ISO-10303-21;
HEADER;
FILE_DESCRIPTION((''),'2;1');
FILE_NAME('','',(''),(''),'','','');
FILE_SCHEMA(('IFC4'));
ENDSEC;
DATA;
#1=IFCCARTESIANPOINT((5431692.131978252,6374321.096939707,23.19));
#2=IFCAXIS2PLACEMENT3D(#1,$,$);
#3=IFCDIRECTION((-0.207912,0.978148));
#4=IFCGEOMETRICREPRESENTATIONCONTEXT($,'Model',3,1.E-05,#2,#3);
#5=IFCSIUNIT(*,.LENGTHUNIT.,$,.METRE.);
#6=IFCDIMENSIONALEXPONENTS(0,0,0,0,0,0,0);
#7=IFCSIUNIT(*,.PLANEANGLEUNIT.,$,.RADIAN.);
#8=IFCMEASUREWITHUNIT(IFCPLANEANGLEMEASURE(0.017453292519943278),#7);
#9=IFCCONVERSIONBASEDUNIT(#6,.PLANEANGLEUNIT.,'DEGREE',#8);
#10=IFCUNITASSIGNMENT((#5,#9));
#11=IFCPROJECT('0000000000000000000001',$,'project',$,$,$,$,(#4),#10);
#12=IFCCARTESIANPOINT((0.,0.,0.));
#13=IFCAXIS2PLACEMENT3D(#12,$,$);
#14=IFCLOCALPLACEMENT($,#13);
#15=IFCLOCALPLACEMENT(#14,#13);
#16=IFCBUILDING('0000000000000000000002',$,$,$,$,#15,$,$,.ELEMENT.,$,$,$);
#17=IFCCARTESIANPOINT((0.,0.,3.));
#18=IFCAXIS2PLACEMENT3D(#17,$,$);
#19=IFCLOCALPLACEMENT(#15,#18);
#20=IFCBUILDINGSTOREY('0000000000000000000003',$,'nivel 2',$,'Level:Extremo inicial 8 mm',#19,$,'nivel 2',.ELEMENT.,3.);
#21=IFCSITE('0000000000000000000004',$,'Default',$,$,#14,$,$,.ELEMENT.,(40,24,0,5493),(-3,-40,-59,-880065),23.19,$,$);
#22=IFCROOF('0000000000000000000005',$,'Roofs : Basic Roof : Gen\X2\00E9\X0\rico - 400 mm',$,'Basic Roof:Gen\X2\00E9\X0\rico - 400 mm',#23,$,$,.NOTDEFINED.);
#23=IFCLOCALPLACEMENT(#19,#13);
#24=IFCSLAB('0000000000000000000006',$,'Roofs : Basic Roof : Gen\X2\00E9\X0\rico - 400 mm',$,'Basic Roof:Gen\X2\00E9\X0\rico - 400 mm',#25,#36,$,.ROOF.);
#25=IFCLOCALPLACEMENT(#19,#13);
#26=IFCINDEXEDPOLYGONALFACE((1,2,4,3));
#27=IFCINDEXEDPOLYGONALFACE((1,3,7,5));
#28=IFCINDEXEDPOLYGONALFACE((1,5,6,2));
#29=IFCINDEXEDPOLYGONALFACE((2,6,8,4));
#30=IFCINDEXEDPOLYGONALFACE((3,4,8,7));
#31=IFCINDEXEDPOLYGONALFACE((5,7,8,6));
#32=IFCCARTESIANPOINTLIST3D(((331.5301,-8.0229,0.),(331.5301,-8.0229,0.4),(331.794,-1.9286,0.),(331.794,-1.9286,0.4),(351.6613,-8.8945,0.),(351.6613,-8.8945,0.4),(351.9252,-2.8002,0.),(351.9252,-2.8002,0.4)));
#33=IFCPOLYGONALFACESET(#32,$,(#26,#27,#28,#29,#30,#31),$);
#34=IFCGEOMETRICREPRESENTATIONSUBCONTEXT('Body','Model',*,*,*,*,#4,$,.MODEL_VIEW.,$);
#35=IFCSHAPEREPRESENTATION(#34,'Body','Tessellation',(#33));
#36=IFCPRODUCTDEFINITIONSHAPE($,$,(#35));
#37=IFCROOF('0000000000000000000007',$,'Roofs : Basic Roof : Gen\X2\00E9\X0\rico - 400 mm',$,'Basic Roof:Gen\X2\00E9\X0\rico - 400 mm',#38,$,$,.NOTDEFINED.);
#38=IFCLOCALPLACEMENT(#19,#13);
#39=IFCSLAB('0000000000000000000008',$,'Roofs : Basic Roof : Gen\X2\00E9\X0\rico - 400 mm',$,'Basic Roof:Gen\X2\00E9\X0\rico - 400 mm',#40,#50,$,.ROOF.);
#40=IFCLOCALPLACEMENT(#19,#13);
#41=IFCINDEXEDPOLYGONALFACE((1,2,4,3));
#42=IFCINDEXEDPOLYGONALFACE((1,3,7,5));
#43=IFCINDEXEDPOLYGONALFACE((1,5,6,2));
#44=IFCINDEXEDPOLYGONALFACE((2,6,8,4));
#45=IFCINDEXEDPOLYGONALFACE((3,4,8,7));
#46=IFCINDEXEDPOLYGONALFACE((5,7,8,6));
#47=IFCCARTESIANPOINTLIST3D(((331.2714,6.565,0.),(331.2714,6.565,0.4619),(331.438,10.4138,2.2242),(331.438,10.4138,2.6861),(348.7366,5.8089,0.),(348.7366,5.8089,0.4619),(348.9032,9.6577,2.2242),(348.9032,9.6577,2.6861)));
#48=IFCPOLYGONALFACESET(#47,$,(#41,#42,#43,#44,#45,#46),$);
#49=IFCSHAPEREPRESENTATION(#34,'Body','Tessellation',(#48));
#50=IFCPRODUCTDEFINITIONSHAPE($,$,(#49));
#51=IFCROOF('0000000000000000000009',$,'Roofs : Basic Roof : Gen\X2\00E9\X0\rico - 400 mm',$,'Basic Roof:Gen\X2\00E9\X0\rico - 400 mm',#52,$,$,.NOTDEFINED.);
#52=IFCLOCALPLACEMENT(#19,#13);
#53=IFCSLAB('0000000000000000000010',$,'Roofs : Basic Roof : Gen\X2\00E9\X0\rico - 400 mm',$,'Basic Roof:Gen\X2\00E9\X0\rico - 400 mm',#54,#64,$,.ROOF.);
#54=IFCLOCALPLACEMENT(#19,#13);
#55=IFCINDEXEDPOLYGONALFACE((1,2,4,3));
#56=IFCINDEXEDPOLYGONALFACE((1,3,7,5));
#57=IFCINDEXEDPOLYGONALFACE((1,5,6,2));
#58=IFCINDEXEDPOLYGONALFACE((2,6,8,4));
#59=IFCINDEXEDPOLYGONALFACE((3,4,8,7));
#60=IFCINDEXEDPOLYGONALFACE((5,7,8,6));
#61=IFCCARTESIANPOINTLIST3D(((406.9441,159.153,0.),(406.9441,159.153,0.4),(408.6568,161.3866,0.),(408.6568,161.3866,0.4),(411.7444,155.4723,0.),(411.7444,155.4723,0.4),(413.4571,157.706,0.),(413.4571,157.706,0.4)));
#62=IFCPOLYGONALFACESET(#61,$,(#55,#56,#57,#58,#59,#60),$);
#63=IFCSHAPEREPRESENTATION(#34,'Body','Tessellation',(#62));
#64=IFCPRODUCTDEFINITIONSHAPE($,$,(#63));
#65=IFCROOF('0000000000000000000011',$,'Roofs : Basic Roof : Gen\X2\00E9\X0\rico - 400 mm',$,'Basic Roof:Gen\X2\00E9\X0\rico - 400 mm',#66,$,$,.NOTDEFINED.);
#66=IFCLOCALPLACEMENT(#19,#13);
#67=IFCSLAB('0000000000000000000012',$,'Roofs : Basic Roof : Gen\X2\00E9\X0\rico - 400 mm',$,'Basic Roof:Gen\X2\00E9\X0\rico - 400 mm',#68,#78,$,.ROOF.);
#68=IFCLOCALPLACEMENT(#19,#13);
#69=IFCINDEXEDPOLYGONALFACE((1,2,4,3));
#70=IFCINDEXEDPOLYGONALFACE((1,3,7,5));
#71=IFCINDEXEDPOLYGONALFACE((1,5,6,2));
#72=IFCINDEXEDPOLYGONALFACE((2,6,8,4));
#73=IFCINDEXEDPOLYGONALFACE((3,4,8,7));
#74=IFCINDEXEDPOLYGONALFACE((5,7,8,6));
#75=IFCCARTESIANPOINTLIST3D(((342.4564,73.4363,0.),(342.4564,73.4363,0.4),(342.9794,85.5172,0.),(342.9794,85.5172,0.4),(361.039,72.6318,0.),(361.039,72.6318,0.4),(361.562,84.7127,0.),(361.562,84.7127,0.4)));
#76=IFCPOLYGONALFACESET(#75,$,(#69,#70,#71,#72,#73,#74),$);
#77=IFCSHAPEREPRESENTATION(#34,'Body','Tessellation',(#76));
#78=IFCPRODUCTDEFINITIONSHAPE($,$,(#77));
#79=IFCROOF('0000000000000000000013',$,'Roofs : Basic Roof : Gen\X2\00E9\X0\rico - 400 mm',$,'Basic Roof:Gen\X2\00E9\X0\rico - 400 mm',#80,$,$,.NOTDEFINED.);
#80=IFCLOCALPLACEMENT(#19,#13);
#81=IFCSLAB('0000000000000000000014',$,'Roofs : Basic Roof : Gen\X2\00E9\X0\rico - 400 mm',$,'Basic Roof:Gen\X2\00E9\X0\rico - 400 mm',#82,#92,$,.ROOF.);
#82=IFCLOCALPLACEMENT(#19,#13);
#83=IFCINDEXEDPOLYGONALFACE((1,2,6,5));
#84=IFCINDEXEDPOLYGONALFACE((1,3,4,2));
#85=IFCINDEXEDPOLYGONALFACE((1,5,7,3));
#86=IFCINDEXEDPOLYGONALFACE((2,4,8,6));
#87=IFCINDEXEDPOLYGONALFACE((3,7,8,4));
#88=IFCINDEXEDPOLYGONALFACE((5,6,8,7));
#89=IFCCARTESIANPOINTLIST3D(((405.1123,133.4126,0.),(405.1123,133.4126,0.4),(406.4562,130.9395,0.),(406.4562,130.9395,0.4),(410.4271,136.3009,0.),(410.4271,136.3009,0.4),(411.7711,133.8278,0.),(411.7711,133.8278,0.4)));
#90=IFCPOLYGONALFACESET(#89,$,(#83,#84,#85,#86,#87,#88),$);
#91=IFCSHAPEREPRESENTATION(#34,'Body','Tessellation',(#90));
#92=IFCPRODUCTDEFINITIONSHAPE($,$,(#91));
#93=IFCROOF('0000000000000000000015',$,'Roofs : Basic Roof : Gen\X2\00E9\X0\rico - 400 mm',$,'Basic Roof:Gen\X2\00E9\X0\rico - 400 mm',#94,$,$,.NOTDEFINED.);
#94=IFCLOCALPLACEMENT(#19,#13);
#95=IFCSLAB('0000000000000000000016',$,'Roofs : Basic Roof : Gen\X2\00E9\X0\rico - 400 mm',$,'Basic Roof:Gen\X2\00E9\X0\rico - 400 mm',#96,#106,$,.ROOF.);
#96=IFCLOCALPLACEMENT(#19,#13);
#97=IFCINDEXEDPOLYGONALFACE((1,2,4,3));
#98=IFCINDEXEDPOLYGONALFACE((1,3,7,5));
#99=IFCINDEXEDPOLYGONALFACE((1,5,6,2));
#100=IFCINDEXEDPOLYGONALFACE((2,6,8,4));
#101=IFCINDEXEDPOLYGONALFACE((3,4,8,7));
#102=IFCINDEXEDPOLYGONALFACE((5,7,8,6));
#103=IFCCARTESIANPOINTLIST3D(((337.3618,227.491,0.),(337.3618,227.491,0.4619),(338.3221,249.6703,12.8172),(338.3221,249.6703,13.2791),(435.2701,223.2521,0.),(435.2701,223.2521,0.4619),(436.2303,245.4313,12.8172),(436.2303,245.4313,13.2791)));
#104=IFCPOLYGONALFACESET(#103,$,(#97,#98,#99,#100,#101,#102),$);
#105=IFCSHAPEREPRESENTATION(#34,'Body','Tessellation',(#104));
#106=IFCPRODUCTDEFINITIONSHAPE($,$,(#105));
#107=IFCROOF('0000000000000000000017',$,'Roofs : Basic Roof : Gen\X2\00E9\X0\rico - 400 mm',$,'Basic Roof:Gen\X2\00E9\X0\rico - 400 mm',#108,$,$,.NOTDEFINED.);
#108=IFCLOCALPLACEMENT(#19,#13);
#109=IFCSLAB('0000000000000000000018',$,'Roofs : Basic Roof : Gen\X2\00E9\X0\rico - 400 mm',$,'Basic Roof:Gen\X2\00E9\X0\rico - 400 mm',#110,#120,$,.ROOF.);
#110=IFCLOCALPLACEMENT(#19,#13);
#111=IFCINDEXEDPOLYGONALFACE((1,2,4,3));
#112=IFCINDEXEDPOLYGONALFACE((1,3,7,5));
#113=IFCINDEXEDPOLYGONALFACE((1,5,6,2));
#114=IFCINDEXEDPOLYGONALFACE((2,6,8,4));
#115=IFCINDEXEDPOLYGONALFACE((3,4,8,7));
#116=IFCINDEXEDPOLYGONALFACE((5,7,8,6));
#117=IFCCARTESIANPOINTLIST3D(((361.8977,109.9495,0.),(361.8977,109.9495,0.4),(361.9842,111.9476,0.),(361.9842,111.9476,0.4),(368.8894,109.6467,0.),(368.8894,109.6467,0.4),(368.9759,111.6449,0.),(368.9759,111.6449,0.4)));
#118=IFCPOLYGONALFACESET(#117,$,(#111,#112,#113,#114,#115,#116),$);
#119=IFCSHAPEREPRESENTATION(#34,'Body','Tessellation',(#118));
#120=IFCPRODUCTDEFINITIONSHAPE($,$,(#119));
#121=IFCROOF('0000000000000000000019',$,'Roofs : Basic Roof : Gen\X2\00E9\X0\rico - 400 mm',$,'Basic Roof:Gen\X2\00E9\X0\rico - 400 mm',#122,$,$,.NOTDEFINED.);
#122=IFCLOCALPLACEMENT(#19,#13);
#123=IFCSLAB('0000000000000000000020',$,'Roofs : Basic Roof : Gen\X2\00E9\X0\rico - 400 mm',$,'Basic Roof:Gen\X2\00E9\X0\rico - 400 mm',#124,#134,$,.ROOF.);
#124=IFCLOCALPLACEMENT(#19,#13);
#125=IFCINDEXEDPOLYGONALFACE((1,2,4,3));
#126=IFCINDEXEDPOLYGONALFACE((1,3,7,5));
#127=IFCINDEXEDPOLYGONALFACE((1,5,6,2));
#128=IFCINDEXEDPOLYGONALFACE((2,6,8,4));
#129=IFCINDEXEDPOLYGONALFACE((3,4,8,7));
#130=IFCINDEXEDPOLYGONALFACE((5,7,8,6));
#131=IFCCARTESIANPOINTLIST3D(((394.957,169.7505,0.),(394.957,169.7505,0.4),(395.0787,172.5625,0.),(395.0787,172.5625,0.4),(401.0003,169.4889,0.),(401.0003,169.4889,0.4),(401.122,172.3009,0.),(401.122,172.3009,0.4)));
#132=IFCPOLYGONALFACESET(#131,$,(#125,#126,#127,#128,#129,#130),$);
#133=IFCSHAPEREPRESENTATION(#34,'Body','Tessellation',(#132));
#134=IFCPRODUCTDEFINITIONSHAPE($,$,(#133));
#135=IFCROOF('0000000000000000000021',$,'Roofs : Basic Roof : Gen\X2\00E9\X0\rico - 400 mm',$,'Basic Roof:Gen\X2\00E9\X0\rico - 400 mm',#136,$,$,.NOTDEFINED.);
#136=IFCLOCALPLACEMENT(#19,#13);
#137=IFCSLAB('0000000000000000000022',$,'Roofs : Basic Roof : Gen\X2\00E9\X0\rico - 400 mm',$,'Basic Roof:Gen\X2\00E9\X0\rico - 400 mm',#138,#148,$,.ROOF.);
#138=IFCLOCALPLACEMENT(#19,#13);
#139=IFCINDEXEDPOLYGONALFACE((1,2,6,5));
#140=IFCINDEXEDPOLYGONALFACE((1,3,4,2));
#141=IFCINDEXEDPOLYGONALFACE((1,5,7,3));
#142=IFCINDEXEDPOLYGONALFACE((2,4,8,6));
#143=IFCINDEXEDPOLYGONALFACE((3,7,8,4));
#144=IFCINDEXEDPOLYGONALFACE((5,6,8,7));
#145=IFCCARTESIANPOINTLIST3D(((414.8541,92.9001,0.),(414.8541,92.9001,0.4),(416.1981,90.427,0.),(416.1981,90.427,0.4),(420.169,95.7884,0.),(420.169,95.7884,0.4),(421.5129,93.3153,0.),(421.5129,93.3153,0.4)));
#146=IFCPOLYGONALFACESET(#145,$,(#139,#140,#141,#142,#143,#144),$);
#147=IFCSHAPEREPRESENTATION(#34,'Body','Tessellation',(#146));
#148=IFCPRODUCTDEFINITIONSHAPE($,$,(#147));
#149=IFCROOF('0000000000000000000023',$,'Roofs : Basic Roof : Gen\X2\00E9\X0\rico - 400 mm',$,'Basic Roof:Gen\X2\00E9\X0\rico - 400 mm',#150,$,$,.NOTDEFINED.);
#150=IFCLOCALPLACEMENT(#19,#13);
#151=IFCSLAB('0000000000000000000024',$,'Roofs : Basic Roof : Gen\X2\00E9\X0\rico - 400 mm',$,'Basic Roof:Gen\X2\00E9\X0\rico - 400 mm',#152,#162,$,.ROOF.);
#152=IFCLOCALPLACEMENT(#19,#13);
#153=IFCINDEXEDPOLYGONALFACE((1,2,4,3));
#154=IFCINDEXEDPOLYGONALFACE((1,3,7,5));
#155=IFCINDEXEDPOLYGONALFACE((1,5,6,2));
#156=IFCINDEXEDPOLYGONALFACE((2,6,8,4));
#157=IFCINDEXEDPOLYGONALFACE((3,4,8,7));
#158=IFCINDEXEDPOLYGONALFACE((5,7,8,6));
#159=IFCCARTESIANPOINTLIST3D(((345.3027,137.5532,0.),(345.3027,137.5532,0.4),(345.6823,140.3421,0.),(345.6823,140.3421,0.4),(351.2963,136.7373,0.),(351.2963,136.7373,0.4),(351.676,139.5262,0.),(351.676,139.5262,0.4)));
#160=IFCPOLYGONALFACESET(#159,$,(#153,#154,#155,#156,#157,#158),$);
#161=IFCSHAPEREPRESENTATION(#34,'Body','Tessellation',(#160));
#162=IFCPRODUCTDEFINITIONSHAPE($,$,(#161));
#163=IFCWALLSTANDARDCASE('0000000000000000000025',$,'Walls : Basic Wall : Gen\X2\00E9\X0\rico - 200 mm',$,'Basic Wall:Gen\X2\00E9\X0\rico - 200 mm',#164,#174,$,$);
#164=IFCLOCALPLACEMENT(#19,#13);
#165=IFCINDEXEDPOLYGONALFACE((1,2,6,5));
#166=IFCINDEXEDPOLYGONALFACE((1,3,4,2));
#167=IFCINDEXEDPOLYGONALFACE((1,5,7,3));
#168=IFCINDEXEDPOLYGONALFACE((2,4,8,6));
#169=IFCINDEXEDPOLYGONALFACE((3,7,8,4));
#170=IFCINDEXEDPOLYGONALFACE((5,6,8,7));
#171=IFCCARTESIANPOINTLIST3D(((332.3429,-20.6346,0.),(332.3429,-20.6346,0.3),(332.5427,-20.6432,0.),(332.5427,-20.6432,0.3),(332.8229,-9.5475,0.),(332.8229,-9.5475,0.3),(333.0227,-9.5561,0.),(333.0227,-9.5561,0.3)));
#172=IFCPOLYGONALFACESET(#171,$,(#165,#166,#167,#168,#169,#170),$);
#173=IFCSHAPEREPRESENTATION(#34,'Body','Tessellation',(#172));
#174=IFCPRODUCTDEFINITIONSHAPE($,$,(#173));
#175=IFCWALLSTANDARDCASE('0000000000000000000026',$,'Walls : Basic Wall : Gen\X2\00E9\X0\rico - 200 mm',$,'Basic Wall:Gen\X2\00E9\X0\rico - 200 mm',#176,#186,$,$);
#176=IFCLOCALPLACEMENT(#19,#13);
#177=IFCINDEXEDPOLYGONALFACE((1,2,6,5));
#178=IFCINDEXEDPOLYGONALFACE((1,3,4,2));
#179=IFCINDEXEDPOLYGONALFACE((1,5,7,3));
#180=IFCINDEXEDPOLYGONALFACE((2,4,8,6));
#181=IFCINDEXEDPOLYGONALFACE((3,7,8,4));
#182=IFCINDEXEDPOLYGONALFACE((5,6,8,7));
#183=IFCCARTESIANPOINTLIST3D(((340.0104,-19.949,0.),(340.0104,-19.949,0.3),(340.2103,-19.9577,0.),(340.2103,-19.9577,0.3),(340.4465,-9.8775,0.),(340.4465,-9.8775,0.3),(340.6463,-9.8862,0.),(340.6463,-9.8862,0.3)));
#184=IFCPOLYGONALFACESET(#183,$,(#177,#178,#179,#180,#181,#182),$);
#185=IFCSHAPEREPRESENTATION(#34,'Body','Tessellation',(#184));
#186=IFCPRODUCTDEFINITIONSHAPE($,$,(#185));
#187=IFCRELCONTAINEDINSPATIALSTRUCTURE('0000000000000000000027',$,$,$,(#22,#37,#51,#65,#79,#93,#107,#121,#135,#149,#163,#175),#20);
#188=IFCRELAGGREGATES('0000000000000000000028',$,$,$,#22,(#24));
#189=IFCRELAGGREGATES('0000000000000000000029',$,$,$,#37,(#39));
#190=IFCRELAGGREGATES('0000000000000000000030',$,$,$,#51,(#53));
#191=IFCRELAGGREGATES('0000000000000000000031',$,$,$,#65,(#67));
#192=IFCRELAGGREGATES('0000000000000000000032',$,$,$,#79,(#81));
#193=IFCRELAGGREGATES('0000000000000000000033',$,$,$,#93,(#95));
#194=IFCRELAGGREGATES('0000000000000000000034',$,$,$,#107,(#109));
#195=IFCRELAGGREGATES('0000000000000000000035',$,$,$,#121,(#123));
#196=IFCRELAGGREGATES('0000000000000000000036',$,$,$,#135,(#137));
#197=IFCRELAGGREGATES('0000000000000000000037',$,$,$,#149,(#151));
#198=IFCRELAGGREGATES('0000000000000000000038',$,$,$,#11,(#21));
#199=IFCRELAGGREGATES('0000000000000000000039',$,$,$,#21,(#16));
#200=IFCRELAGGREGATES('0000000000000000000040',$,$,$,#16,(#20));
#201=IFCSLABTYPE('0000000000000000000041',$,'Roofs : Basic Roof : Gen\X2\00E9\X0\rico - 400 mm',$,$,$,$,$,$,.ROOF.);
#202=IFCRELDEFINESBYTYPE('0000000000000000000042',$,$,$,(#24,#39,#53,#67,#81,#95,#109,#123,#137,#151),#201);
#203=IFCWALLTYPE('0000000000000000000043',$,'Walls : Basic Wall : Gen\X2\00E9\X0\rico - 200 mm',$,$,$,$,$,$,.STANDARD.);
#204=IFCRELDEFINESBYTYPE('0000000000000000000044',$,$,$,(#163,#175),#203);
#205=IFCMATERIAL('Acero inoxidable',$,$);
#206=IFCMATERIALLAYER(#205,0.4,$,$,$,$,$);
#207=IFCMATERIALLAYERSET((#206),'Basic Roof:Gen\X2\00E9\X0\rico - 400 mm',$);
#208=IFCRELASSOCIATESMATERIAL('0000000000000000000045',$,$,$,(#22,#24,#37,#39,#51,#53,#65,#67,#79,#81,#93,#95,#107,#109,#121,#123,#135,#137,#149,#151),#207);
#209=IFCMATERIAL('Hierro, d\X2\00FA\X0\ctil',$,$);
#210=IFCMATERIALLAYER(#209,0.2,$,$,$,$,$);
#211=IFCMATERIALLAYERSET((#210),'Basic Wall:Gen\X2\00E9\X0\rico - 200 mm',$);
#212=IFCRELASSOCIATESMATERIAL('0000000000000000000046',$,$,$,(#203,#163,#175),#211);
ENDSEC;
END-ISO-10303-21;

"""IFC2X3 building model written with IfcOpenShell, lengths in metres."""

from ifc_helpers import new_model, entity, si_unit, converted_unit, direction, frame, frame_2d, origin, place, context, subcontext, project, spatial, rectangle, extrude, material, layer, layer_set, layer_usage, type_object, element, aggregate, save


model = new_model("IFC2X3")

# Units and contexts
model_context = context("Model", 3, precision=1e-05, world=frame((5431692.131978252, 6374321.096939707, 23.19)), true_north=direction((-0.207912, 0.978148)))
body_context = subcontext(model_context, "Body", "Model", "MODEL_VIEW")
ifc_project = project(units=[si_unit("LENGTHUNIT", "METRE"), converted_unit("PLANEANGLEUNIT", "DEGREE", entity("IfcPlaneAngleMeasure", 0.017453292519943278), si_unit("PLANEANGLEUNIT", "RADIAN"), dimensions=[0, 0, 0, 0, 0, 0, 0])], contexts=[model_context])

# Site, building, storey
site_placement = place(None, origin())
site = spatial("IfcSite", under=ifc_project, at=site_placement, Name="Default", CompositionType="ELEMENT", RefLatitude=(40, 24, 0, 5493), RefLongitude=(-3, -40, -59, -880065), RefElevation=23.19)
building_placement = place(site_placement, origin())
building = spatial("IfcBuilding", under=site, at=building_placement, CompositionType="ELEMENT")
storey_placement = place(building_placement, frame((0.0, 0.0, 3.0)))
storey = spatial("IfcBuildingStorey", under=building, at=storey_placement, Name="nivel 2", ObjectType="Level:Extremo inicial 8 mm", LongName="nivel 2", CompositionType="ELEMENT", Elevation=3.0)

# Roof, slab
ifc_material_1 = material(Name="Acero inoxidable")
ifc_layer_1 = layer(ifc_material_1, 0.4)
ifc_layer_set_1 = layer_set([ifc_layer_1], Name="Basic Roof:Genérico - 400 mm")
roof_1_placement = place(storey_placement, frame((331.5301, -8.8945, 0.0)))
roof_1 = element("IfcRoof", 1, at=roof_1_placement, inside=storey, material=ifc_layer_set_1, Name="Roofs : Basic Roof : Genérico - 400 mm", ObjectType="Basic Roof:Genérico - 400 mm", ShapeType="NOTDEFINED")
slab_type = type_object("IfcSlabType", Name="Roofs : Basic Roof : Genérico - 400 mm", PredefinedType="ROOF")
slab_1_placement = place(roof_1_placement, origin())
slab_1 = element("IfcSlab", 2, at=slab_1_placement, type_object=slab_type, material=ifc_layer_set_1, Name="Roofs : Basic Roof : Genérico - 400 mm", ObjectType="Basic Roof:Genérico - 400 mm", PredefinedType="ROOF", context=body_context, shape_type="SweptSolid", body=[
    extrude(rectangle(XDim=6.1, YDim=20.1501, at=frame_2d((0.0, 0.0), x_axis=(0.043255, 0.999064))), frame((10.1975, 3.4829, 0.0)), (0.0, 0.0, 1.0), 0.4),
])
aggregate(roof_1, [slab_1])

# Roof, slab
roof_2_placement = place(storey_placement, frame((331.2714, 5.8089, 0.0)))
roof_2 = element("IfcRoof", 3, at=roof_2_placement, inside=storey, material=ifc_layer_set_1, Name="Roofs : Basic Roof : Genérico - 400 mm", ObjectType="Basic Roof:Genérico - 400 mm", ShapeType="NOTDEFINED")
slab_2_placement = place(roof_2_placement, origin())
slab_2 = element("IfcSlab", 4, at=slab_2_placement, type_object=slab_type, material=ifc_layer_set_1, Name="Roofs : Basic Roof : Genérico - 400 mm", ObjectType="Basic Roof:Genérico - 400 mm", PredefinedType="ROOF", context=body_context, shape_type="SweptSolid", body=[
    extrude(rectangle(XDim=4.4484, YDim=17.4816, at=frame_2d((0.0, 0.0), x_axis=(0.037468, 0.999298))), frame((8.8159, 2.3025, 1.1121), z_axis=(-0.021627, -0.499532, 0.866025), x_axis=(0.999766, -0.010806, 0.018734)), (0.018734, 0.499649, 0.866025), 0.4619),
])
aggregate(roof_2, [slab_2])

# Roofs, slabs
roof_3_placement = place(storey_placement, frame((406.9441, 155.4723, 0.0)))
roof_3 = element("IfcRoof", 5, at=roof_3_placement, inside=storey, material=ifc_layer_set_1, Name="Roofs : Basic Roof : Genérico - 400 mm", ObjectType="Basic Roof:Genérico - 400 mm", ShapeType="NOTDEFINED")
slab_3_placement = place(roof_3_placement, origin())
slab_3 = element("IfcSlab", 6, at=slab_3_placement, type_object=slab_type, material=ifc_layer_set_1, Name="Roofs : Basic Roof : Genérico - 400 mm", ObjectType="Basic Roof:Genérico - 400 mm", PredefinedType="ROOF", context=body_context, shape_type="SweptSolid", body=[
    extrude(rectangle(XDim=6.049, YDim=2.8147, at=frame_2d((0.0, 0.0), x_axis=(-0.793576, 0.608472))), frame((3.2565, 2.9571, 0.0)), (0.0, 0.0, 1.0), 0.4),
])
aggregate(roof_3, [slab_3])
roof_4_placement = place(storey_placement, frame((342.4564, 72.6318, 0.0)))
roof_4 = element("IfcRoof", 7, at=roof_4_placement, inside=storey, material=ifc_layer_set_1, Name="Roofs : Basic Roof : Genérico - 400 mm", ObjectType="Basic Roof:Genérico - 400 mm", ShapeType="NOTDEFINED")
slab_4_placement = place(roof_4_placement, origin())
slab_4 = element("IfcSlab", 8, at=slab_4_placement, type_object=slab_type, material=ifc_layer_set_1, Name="Roofs : Basic Roof : Genérico - 400 mm", ObjectType="Basic Roof:Genérico - 400 mm", PredefinedType="ROOF", context=body_context, shape_type="SweptSolid", body=[
    extrude(rectangle(XDim=18.6, YDim=12.0922, at=frame_2d((0.0, 0.0), x_axis=(-0.999064, 0.043255))), frame((9.5528, 6.4427, 0.0)), (0.0, 0.0, 1.0), 0.4),
])
aggregate(roof_4, [slab_4])
roof_5_placement = place(storey_placement, frame((405.1123, 130.9395, 0.0)))
roof_5 = element("IfcRoof", 9, at=roof_5_placement, inside=storey, material=ifc_layer_set_1, Name="Roofs : Basic Roof : Genérico - 400 mm", ObjectType="Basic Roof:Genérico - 400 mm", ShapeType="NOTDEFINED")
slab_5_placement = place(roof_5_placement, origin())
slab_5 = element("IfcSlab", 10, at=slab_5_placement, type_object=slab_type, material=ifc_layer_set_1, Name="Roofs : Basic Roof : Genérico - 400 mm", ObjectType="Basic Roof:Genérico - 400 mm", PredefinedType="ROOF", context=body_context, shape_type="SweptSolid", body=[
    extrude(rectangle(XDim=6.049, YDim=2.8147, at=frame_2d((0.0, 0.0), x_axis=(-0.878643, -0.47748))), frame((3.3294, 2.6807, 0.0)), (0.0, 0.0, 1.0), 0.4),
])
aggregate(roof_5, [slab_5])

# Roof, slab
roof_6_placement = place(storey_placement, frame((337.3618, 223.2521, 0.0)))
roof_6 = element("IfcRoof", 11, at=roof_6_placement, inside=storey, material=ifc_layer_set_1, Name="Roofs : Basic Roof : Genérico - 400 mm", ObjectType="Basic Roof:Genérico - 400 mm", ShapeType="NOTDEFINED")
slab_6_placement = place(roof_6_placement, origin())
slab_6 = element("IfcSlab", 12, at=slab_6_placement, type_object=slab_type, material=ifc_layer_set_1, Name="Roofs : Basic Roof : Genérico - 400 mm", ObjectType="Basic Roof:Genérico - 400 mm", PredefinedType="ROOF", context=body_context, shape_type="SweptSolid", body=[
    extrude(rectangle(XDim=25.6344, YDim=98.0, at=frame_2d((0.0, 0.0), x_axis=(0.037468, 0.999298))), frame((49.4343, 13.2091, 6.4086), z_axis=(-0.021627, -0.499532, 0.866025), x_axis=(0.999766, -0.010806, 0.018734)), (0.018734, 0.499649, 0.866025), 0.4619),
])
aggregate(roof_6, [slab_6])

# Roofs, slabs
roof_7_placement = place(storey_placement, frame((361.8977, 109.6467, 0.0)))
roof_7 = element("IfcRoof", 13, at=roof_7_placement, inside=storey, material=ifc_layer_set_1, Name="Roofs : Basic Roof : Genérico - 400 mm", ObjectType="Basic Roof:Genérico - 400 mm", ShapeType="NOTDEFINED")
slab_7_placement = place(roof_7_placement, origin())
slab_7 = element("IfcSlab", 14, at=slab_7_placement, type_object=slab_type, material=ifc_layer_set_1, Name="Roofs : Basic Roof : Genérico - 400 mm", ObjectType="Basic Roof:Genérico - 400 mm", PredefinedType="ROOF", context=body_context, shape_type="SweptSolid", body=[
    extrude(rectangle(XDim=6.9983, YDim=2.0, at=frame_2d((0.0, 0.0), x_axis=(0.999064, -0.043255))), frame((3.5391, 1.1504, 0.0)), (0.0, 0.0, 1.0), 0.4),
])
aggregate(roof_7, [slab_7])
roof_8_placement = place(storey_placement, frame((394.957, 169.4889, 0.0)))
roof_8 = element("IfcRoof", 15, at=roof_8_placement, inside=storey, material=ifc_layer_set_1, Name="Roofs : Basic Roof : Genérico - 400 mm", ObjectType="Basic Roof:Genérico - 400 mm", ShapeType="NOTDEFINED")
slab_8_placement = place(roof_8_placement, origin())
slab_8 = element("IfcSlab", 16, at=slab_8_placement, type_object=slab_type, material=ifc_layer_set_1, Name="Roofs : Basic Roof : Genérico - 400 mm", ObjectType="Basic Roof:Genérico - 400 mm", PredefinedType="ROOF", context=body_context, shape_type="SweptSolid", body=[
    extrude(rectangle(XDim=6.049, YDim=2.8147, at=frame_2d((0.0, 0.0), x_axis=(-0.999064, 0.043255))), frame((3.0825, 1.5368, 0.0)), (0.0, 0.0, 1.0), 0.4),
])
aggregate(roof_8, [slab_8])
roof_9_placement = place(storey_placement, frame((414.8541, 90.427, 0.0)))
roof_9 = element("IfcRoof", 17, at=roof_9_placement, inside=storey, material=ifc_layer_set_1, Name="Roofs : Basic Roof : Genérico - 400 mm", ObjectType="Basic Roof:Genérico - 400 mm", ShapeType="NOTDEFINED")
slab_9_placement = place(roof_9_placement, origin())
slab_9 = element("IfcSlab", 18, at=slab_9_placement, type_object=slab_type, material=ifc_layer_set_1, Name="Roofs : Basic Roof : Genérico - 400 mm", ObjectType="Basic Roof:Genérico - 400 mm", PredefinedType="ROOF", context=body_context, shape_type="SweptSolid", body=[
    extrude(rectangle(XDim=6.049, YDim=2.8147, at=frame_2d((0.0, 0.0), x_axis=(-0.878643, -0.47748))), frame((3.3294, 2.6807, 0.0)), (0.0, 0.0, 1.0), 0.4),
])
aggregate(roof_9, [slab_9])
roof_10_placement = place(storey_placement, frame((345.3027, 136.7373, 0.0)))
roof_10 = element("IfcRoof", 19, at=roof_10_placement, inside=storey, material=ifc_layer_set_1, Name="Roofs : Basic Roof : Genérico - 400 mm", ObjectType="Basic Roof:Genérico - 400 mm", ShapeType="NOTDEFINED")
slab_10_placement = place(roof_10_placement, origin())
slab_10 = element("IfcSlab", 20, at=slab_10_placement, type_object=slab_type, material=ifc_layer_set_1, Name="Roofs : Basic Roof : Genérico - 400 mm", ObjectType="Basic Roof:Genérico - 400 mm", PredefinedType="ROOF", context=body_context, shape_type="SweptSolid", body=[
    extrude(rectangle(XDim=6.049, YDim=2.8147, at=frame_2d((0.0, 0.0), x_axis=(0.990862, -0.134876))), frame((3.1867, 1.8024, 0.0)), (0.0, 0.0, 1.0), 0.4),
])
aggregate(roof_10, [slab_10])

# Walls
ifc_material_2 = material(Name="Hierro, dúctil")
ifc_layer_2 = layer(ifc_material_2, 0.2)
ifc_layer_set_2 = layer_set([ifc_layer_2], Name="Basic Wall:Genérico - 200 mm")
ifc_layer_usage_1 = layer_usage(ifc_layer_set_2, "AXIS2", "NEGATIVE", 0.1)
wall_type = type_object("IfcWallType", Name="Walls : Basic Wall : Genérico - 200 mm", PredefinedType="STANDARD", material=ifc_layer_set_2)
wall_1_placement = place(storey_placement, frame((332.4428, -20.6389, 0.0), z_axis=(0.0, 0.0, 1.0), x_axis=(0.043255, 0.999064, 0.0)))
element("IfcWallStandardCase", 21, at=wall_1_placement, inside=storey, type_object=wall_type, material=ifc_layer_usage_1, Name="Walls : Basic Wall : Genérico - 200 mm", ObjectType="Basic Wall:Genérico - 200 mm", context=body_context, shape_type="SweptSolid", body=[
    extrude(rectangle(XDim=11.0975, YDim=0.2, at=frame_2d((5.5487, 0.0), x_axis=(-1.0, 0.0))), origin(), (0.0, 0.0, 1.0), 0.3),
])
ifc_layer_usage_2 = layer_usage(ifc_layer_set_2, "AXIS2", "NEGATIVE", 0.1)
wall_2_placement = place(storey_placement, frame((340.1103, -19.9533, 0.0), z_axis=(0.0, 0.0, 1.0), x_axis=(0.043255, 0.999064, 0.0)))
element("IfcWallStandardCase", 22, at=wall_2_placement, inside=storey, type_object=wall_type, material=ifc_layer_usage_2, Name="Walls : Basic Wall : Genérico - 200 mm", ObjectType="Basic Wall:Genérico - 200 mm", context=body_context, shape_type="SweptSolid", body=[
    extrude(rectangle(XDim=10.0809, YDim=0.2, at=frame_2d((5.0405, 0.0), x_axis=(-1.0, 0.0))), origin(), (0.0, 0.0, 1.0), 0.3),
])

save(model, "model.ifc")
